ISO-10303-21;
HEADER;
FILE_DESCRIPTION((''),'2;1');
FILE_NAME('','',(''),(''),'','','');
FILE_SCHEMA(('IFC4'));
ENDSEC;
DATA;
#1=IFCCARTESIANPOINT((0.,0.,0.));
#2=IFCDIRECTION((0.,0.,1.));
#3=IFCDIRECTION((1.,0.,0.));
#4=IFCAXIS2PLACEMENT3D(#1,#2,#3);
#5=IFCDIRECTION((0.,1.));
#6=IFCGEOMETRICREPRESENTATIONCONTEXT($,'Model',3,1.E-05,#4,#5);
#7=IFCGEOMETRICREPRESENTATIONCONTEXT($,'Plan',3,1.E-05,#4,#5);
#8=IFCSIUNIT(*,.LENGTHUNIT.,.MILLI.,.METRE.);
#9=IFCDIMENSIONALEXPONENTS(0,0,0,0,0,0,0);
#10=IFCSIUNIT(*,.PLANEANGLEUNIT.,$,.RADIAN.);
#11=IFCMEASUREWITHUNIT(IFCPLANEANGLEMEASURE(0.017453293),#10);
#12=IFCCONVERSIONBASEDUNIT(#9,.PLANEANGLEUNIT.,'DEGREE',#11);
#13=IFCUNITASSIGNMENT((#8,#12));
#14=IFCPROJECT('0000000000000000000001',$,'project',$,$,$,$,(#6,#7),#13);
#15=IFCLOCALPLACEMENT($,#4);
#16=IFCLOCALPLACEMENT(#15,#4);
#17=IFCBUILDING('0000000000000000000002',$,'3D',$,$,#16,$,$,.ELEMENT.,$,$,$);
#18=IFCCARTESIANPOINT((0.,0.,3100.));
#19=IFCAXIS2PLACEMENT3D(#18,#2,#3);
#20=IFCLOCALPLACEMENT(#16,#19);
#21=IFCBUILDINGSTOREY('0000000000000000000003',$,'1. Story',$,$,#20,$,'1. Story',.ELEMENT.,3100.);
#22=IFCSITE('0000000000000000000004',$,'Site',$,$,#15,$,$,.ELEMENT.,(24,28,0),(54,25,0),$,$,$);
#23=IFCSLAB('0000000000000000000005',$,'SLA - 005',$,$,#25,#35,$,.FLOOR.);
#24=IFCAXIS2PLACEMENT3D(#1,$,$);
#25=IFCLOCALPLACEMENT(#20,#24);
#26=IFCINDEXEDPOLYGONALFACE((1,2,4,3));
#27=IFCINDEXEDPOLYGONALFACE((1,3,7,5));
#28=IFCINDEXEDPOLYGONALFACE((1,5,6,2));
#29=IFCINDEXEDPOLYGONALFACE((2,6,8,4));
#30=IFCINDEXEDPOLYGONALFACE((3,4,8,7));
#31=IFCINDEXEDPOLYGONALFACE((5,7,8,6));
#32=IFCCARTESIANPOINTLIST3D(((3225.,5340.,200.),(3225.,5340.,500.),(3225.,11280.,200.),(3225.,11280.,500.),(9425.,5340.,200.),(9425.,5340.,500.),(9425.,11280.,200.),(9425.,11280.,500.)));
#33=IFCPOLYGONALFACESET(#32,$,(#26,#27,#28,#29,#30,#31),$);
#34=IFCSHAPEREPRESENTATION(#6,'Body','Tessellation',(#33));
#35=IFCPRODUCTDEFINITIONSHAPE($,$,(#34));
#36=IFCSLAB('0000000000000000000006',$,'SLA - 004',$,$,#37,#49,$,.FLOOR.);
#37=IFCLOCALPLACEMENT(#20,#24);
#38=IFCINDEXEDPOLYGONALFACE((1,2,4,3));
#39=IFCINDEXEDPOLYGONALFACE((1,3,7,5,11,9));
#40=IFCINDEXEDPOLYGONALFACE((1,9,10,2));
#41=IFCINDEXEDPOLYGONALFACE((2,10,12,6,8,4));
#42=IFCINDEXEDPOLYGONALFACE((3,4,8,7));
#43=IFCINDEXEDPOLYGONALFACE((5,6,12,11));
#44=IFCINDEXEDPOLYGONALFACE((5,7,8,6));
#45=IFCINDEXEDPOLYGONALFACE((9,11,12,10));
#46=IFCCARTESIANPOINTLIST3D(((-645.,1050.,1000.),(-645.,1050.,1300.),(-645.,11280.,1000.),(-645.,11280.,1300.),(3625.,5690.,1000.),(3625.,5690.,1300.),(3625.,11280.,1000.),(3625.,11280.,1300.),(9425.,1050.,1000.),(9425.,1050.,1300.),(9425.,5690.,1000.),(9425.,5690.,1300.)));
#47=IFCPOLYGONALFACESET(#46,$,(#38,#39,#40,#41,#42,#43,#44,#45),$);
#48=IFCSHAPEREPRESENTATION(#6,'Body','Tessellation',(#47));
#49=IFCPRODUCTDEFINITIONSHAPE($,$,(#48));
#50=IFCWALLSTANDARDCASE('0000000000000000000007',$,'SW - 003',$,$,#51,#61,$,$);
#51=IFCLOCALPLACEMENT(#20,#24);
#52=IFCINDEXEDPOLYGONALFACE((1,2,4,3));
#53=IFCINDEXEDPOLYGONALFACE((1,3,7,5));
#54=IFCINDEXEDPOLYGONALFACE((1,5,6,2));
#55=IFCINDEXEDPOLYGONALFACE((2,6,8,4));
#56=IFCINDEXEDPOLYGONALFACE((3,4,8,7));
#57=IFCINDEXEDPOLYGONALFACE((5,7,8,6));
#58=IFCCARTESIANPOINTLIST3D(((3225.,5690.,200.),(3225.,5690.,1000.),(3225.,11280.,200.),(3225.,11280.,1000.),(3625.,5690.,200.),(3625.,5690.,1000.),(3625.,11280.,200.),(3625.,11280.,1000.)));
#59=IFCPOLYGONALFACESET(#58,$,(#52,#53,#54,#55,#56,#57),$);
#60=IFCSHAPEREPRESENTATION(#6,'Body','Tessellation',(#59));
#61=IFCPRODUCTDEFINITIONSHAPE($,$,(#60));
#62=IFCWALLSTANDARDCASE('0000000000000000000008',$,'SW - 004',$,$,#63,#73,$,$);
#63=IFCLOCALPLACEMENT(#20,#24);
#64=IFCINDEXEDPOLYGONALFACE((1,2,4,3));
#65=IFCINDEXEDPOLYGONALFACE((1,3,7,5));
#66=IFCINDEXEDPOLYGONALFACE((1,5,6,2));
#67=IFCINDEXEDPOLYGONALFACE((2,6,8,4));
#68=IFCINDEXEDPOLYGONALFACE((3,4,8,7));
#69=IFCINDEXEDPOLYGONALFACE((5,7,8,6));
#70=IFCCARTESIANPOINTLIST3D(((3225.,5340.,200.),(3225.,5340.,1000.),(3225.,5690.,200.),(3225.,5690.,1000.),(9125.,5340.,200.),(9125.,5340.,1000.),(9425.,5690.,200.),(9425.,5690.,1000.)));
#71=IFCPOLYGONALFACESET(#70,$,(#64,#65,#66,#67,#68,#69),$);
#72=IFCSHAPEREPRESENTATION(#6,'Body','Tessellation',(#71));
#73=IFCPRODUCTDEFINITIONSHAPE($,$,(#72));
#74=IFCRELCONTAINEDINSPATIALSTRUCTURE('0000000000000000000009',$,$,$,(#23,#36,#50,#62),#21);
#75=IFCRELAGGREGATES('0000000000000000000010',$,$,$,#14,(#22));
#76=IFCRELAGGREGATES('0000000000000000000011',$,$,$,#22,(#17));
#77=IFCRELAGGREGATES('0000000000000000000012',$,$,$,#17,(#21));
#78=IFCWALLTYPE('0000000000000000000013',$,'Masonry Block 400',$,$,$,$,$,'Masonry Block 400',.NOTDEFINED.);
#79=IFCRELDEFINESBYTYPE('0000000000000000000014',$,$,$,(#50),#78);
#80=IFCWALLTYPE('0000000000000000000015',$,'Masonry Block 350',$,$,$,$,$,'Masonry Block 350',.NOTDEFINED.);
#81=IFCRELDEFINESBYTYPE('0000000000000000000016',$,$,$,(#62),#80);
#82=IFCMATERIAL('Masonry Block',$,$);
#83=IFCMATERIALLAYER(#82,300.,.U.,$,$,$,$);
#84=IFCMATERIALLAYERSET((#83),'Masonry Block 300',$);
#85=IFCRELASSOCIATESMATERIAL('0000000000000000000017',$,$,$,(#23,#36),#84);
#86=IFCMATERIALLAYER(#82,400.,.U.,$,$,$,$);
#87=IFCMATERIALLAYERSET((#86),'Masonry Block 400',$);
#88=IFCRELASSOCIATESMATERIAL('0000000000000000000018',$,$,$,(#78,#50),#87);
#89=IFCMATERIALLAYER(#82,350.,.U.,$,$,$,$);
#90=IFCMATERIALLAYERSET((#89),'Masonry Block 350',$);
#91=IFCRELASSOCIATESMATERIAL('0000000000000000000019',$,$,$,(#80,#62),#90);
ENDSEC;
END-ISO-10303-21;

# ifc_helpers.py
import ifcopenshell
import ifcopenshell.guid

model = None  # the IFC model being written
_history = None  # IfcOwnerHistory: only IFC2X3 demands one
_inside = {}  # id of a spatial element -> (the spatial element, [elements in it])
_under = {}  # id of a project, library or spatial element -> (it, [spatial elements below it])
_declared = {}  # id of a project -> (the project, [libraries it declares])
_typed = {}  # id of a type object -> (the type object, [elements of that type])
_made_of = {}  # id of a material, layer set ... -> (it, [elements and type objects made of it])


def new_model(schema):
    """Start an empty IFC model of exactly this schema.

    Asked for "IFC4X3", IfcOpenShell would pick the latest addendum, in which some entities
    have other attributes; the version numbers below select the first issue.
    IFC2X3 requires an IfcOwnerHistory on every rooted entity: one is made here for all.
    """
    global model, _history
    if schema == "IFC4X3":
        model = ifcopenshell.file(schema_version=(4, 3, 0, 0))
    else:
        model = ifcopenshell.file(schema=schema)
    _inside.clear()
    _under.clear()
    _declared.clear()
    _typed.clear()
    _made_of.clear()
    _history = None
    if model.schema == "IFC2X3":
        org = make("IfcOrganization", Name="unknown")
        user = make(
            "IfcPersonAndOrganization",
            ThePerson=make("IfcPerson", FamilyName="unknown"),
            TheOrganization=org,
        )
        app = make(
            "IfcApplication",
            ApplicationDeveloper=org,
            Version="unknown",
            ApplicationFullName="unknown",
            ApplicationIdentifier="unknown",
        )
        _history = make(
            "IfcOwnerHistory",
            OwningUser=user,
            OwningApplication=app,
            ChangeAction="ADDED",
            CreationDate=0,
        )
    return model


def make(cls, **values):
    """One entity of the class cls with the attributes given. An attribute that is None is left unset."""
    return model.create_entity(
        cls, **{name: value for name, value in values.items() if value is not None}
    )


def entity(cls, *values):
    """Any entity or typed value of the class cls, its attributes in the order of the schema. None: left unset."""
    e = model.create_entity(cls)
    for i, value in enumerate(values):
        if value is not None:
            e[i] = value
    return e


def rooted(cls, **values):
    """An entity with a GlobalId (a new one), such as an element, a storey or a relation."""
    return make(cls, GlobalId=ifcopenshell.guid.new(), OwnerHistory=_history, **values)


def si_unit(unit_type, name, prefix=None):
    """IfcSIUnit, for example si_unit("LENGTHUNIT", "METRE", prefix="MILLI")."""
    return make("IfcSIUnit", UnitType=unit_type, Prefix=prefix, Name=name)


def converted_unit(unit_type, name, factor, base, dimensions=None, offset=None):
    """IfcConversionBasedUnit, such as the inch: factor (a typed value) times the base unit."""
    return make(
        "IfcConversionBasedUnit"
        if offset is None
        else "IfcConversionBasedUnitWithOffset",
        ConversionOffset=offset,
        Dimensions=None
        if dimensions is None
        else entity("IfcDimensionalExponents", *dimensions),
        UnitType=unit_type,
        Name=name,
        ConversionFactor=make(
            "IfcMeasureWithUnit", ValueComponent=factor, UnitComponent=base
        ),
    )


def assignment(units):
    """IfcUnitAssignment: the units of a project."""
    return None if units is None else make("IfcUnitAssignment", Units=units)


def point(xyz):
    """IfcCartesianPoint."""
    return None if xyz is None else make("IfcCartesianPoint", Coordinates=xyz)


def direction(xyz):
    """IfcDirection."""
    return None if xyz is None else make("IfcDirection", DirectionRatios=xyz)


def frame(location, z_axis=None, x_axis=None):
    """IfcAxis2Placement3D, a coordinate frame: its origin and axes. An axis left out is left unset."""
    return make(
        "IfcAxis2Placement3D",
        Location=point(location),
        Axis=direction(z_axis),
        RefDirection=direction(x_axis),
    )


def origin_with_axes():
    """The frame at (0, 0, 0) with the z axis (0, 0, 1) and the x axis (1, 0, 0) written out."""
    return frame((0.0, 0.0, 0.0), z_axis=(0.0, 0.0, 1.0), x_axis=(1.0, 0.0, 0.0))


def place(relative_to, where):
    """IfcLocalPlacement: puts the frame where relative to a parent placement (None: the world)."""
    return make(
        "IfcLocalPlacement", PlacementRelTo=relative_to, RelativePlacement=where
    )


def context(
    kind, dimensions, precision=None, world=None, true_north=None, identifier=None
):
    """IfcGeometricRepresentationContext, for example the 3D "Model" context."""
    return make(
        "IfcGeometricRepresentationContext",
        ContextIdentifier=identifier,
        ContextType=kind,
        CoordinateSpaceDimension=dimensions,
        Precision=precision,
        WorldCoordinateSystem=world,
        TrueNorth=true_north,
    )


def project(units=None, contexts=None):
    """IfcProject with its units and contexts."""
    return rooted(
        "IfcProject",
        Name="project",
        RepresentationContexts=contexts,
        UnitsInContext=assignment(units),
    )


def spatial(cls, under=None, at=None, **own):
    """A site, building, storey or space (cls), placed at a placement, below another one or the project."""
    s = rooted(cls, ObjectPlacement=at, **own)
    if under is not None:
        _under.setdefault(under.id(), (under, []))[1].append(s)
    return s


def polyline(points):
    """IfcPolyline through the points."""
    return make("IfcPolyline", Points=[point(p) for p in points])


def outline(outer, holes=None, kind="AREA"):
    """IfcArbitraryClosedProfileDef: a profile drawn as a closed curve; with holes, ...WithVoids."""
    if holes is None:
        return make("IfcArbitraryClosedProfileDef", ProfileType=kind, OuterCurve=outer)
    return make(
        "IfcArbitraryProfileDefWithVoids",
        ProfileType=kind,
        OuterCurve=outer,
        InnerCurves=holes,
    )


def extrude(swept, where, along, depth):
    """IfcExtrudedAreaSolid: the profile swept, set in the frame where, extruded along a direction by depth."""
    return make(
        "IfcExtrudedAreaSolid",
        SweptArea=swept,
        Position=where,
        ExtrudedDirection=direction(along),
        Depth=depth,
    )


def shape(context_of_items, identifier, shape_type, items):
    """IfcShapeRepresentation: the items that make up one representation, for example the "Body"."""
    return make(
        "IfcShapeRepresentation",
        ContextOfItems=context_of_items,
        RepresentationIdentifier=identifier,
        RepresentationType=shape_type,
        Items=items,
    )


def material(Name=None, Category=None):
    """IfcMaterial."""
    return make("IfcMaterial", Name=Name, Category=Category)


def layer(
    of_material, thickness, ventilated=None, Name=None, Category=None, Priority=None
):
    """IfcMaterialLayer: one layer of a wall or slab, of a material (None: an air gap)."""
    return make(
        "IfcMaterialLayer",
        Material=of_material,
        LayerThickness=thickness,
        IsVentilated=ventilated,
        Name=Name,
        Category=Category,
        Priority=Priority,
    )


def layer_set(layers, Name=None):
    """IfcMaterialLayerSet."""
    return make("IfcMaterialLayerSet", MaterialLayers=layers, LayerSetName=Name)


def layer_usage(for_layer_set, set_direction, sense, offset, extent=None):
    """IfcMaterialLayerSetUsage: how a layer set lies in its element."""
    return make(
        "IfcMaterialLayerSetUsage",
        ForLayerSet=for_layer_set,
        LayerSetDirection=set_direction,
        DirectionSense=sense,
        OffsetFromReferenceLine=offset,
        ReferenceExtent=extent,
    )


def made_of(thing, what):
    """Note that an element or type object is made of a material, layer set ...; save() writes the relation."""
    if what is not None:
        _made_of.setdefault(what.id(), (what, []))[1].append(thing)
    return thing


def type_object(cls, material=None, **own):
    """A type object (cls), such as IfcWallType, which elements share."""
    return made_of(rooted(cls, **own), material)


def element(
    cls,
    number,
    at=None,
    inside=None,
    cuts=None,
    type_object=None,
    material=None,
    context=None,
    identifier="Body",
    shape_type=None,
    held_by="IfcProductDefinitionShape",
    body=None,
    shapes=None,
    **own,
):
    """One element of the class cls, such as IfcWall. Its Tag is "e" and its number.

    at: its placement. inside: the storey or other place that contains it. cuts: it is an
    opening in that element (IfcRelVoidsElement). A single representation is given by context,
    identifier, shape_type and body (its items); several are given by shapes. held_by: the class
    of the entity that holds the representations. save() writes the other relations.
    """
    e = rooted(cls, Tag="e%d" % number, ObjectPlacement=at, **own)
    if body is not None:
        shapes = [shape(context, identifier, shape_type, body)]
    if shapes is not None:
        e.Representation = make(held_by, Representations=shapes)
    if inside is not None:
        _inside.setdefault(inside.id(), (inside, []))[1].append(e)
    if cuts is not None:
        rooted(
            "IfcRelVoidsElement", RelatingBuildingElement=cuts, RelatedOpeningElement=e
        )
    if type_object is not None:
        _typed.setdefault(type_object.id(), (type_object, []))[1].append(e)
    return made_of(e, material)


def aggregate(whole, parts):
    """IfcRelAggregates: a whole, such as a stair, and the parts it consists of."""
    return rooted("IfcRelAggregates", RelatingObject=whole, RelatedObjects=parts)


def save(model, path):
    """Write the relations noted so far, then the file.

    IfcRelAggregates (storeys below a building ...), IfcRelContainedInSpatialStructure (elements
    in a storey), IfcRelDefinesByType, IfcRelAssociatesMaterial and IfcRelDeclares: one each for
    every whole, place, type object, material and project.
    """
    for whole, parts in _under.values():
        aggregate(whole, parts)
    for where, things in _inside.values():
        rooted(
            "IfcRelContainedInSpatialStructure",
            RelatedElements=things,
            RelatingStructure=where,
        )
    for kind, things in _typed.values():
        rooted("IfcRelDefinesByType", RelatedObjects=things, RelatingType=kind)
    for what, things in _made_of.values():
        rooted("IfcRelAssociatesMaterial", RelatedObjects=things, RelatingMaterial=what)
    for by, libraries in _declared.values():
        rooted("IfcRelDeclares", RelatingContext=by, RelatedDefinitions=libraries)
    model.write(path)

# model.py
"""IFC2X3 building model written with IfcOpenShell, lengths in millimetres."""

from ifc_helpers import new_model, entity, si_unit, converted_unit, direction, frame, origin_with_axes, place, context, project, spatial, polyline, outline, extrude, material, layer, layer_set, layer_usage, type_object, element, save


model = new_model("IFC2X3")

# Units and contexts
model_context = context("Model", 3, precision=1e-05, world=origin_with_axes(), true_north=direction((0.0, 1.0)))
plan_context = context("Plan", 3, precision=1e-05, world=origin_with_axes(), true_north=direction((0.0, 1.0)))
ifc_project = project(units=[si_unit("LENGTHUNIT", "METRE", prefix="MILLI"), converted_unit("PLANEANGLEUNIT", "DEGREE", entity("IfcPlaneAngleMeasure", 0.017453293), si_unit("PLANEANGLEUNIT", "RADIAN"), dimensions=[0, 0, 0, 0, 0, 0, 0])], contexts=[model_context, plan_context])

# Site, building, storey
site_placement = place(None, origin_with_axes())
site = spatial("IfcSite", under=ifc_project, at=site_placement, Name="Site", CompositionType="ELEMENT", RefLatitude=(24, 28, 0), RefLongitude=(54, 25, 0))
building_placement = place(site_placement, origin_with_axes())
building = spatial("IfcBuilding", under=site, at=building_placement, Name="3D", CompositionType="ELEMENT")
storey_placement = place(building_placement, frame((0.0, 0.0, 3100.0), z_axis=(0.0, 0.0, 1.0), x_axis=(1.0, 0.0, 0.0)))
storey = spatial("IfcBuildingStorey", under=building, at=storey_placement, Name="1. Story", LongName="1. Story", CompositionType="ELEMENT", Elevation=3100.0)

# Slabs
ifc_material = material(Name="Masonry Block")
ifc_layer_1 = layer(ifc_material, 300.0, ventilated="UNKNOWN")
ifc_layer_set_1 = layer_set([ifc_layer_1], Name="Masonry Block 300")
ifc_layer_usage_1 = layer_usage(ifc_layer_set_1, "AXIS3", "NEGATIVE", 300.0)
slab_1_placement = place(storey_placement, frame((3225.0, 11280.0, 200.0), z_axis=(0.0, 0.0, 1.0), x_axis=(1.0, 0.0, 0.0)))
element("IfcSlab", 1, at=slab_1_placement, inside=storey, material=ifc_layer_usage_1, Name="SLA - 005", PredefinedType="FLOOR", context=model_context, shape_type="SweptSolid", body=[
    extrude(outline(polyline([(0.0, 0.0), (6200.0, 0.0), (6200.0, -5940.0), (0.0, -5940.0), (0.0, 0.0)])), origin_with_axes(), (0.0, 0.0, 1.0), 300.0),
])
ifc_layer_usage_2 = layer_usage(ifc_layer_set_1, "AXIS3", "NEGATIVE", 300.0)
slab_2_placement = place(storey_placement, frame((-645.0, 11280.0, 1000.0), z_axis=(0.0, 0.0, 1.0), x_axis=(1.0, 0.0, 0.0)))
element("IfcSlab", 2, at=slab_2_placement, inside=storey, material=ifc_layer_usage_2, Name="SLA - 004", PredefinedType="FLOOR", context=model_context, shape_type="SweptSolid", body=[
    extrude(outline(polyline([(0.0, 0.0), (4270.0, 0.0), (4270.0, -5590.0), (10070.0, -5590.0), (10070.0, -10230.0), (0.0, -10230.0), (0.0, 0.0)])), origin_with_axes(), (0.0, 0.0, 1.0), 300.0),
])

# Walls
ifc_layer_2 = layer(ifc_material, 400.0, ventilated="UNKNOWN")
ifc_layer_set_2 = layer_set([ifc_layer_2], Name="Masonry Block 400")
ifc_layer_usage_3 = layer_usage(ifc_layer_set_2, "AXIS2", "NEGATIVE", 0.0)
wall_type_1 = type_object("IfcWallType", Name="Masonry Block 400", ElementType="Masonry Block 400", PredefinedType="NOTDEFINED", material=ifc_layer_set_2)
wall_1_placement = place(storey_placement, frame((3625.0, 11280.0, 200.0), z_axis=(0.0, 0.0, 1.0), x_axis=(0.0, -1.0, 0.0)))
element("IfcWallStandardCase", 3, at=wall_1_placement, inside=storey, type_object=wall_type_1, material=ifc_layer_usage_3, Name="SW - 003", context=model_context, shape_type="SweptSolid", body=[
    extrude(outline(polyline([(0.0, -400.0), (5590.0, -400.0), (5590.0, 0.0), (0.0, 0.0), (0.0, -400.0)])), origin_with_axes(), (0.0, 0.0, 1.0), 800.0),
])
ifc_layer_3 = layer(ifc_material, 350.0, ventilated="UNKNOWN")
ifc_layer_set_3 = layer_set([ifc_layer_3], Name="Masonry Block 350")
ifc_layer_usage_4 = layer_usage(ifc_layer_set_3, "AXIS2", "NEGATIVE", 0.0)
wall_type_2 = type_object("IfcWallType", Name="Masonry Block 350", ElementType="Masonry Block 350", PredefinedType="NOTDEFINED", material=ifc_layer_set_3)
wall_2_placement = place(storey_placement, frame((9425.0, 5340.0, 200.0), z_axis=(0.0, 0.0, 1.0), x_axis=(-1.0, 0.0, 0.0)))
element("IfcWallStandardCase", 4, at=wall_2_placement, inside=storey, type_object=wall_type_2, material=ifc_layer_usage_4, Name="SW - 004", context=model_context, shape_type="SweptSolid", body=[
    extrude(outline(polyline([(0.0, -350.0), (6200.0, -350.0), (6200.0, 0.0), (300.0, 0.0), (0.0, -350.0)])), origin_with_axes(), (0.0, 0.0, 1.0), 800.0),
])

save(model, "model.ifc")
